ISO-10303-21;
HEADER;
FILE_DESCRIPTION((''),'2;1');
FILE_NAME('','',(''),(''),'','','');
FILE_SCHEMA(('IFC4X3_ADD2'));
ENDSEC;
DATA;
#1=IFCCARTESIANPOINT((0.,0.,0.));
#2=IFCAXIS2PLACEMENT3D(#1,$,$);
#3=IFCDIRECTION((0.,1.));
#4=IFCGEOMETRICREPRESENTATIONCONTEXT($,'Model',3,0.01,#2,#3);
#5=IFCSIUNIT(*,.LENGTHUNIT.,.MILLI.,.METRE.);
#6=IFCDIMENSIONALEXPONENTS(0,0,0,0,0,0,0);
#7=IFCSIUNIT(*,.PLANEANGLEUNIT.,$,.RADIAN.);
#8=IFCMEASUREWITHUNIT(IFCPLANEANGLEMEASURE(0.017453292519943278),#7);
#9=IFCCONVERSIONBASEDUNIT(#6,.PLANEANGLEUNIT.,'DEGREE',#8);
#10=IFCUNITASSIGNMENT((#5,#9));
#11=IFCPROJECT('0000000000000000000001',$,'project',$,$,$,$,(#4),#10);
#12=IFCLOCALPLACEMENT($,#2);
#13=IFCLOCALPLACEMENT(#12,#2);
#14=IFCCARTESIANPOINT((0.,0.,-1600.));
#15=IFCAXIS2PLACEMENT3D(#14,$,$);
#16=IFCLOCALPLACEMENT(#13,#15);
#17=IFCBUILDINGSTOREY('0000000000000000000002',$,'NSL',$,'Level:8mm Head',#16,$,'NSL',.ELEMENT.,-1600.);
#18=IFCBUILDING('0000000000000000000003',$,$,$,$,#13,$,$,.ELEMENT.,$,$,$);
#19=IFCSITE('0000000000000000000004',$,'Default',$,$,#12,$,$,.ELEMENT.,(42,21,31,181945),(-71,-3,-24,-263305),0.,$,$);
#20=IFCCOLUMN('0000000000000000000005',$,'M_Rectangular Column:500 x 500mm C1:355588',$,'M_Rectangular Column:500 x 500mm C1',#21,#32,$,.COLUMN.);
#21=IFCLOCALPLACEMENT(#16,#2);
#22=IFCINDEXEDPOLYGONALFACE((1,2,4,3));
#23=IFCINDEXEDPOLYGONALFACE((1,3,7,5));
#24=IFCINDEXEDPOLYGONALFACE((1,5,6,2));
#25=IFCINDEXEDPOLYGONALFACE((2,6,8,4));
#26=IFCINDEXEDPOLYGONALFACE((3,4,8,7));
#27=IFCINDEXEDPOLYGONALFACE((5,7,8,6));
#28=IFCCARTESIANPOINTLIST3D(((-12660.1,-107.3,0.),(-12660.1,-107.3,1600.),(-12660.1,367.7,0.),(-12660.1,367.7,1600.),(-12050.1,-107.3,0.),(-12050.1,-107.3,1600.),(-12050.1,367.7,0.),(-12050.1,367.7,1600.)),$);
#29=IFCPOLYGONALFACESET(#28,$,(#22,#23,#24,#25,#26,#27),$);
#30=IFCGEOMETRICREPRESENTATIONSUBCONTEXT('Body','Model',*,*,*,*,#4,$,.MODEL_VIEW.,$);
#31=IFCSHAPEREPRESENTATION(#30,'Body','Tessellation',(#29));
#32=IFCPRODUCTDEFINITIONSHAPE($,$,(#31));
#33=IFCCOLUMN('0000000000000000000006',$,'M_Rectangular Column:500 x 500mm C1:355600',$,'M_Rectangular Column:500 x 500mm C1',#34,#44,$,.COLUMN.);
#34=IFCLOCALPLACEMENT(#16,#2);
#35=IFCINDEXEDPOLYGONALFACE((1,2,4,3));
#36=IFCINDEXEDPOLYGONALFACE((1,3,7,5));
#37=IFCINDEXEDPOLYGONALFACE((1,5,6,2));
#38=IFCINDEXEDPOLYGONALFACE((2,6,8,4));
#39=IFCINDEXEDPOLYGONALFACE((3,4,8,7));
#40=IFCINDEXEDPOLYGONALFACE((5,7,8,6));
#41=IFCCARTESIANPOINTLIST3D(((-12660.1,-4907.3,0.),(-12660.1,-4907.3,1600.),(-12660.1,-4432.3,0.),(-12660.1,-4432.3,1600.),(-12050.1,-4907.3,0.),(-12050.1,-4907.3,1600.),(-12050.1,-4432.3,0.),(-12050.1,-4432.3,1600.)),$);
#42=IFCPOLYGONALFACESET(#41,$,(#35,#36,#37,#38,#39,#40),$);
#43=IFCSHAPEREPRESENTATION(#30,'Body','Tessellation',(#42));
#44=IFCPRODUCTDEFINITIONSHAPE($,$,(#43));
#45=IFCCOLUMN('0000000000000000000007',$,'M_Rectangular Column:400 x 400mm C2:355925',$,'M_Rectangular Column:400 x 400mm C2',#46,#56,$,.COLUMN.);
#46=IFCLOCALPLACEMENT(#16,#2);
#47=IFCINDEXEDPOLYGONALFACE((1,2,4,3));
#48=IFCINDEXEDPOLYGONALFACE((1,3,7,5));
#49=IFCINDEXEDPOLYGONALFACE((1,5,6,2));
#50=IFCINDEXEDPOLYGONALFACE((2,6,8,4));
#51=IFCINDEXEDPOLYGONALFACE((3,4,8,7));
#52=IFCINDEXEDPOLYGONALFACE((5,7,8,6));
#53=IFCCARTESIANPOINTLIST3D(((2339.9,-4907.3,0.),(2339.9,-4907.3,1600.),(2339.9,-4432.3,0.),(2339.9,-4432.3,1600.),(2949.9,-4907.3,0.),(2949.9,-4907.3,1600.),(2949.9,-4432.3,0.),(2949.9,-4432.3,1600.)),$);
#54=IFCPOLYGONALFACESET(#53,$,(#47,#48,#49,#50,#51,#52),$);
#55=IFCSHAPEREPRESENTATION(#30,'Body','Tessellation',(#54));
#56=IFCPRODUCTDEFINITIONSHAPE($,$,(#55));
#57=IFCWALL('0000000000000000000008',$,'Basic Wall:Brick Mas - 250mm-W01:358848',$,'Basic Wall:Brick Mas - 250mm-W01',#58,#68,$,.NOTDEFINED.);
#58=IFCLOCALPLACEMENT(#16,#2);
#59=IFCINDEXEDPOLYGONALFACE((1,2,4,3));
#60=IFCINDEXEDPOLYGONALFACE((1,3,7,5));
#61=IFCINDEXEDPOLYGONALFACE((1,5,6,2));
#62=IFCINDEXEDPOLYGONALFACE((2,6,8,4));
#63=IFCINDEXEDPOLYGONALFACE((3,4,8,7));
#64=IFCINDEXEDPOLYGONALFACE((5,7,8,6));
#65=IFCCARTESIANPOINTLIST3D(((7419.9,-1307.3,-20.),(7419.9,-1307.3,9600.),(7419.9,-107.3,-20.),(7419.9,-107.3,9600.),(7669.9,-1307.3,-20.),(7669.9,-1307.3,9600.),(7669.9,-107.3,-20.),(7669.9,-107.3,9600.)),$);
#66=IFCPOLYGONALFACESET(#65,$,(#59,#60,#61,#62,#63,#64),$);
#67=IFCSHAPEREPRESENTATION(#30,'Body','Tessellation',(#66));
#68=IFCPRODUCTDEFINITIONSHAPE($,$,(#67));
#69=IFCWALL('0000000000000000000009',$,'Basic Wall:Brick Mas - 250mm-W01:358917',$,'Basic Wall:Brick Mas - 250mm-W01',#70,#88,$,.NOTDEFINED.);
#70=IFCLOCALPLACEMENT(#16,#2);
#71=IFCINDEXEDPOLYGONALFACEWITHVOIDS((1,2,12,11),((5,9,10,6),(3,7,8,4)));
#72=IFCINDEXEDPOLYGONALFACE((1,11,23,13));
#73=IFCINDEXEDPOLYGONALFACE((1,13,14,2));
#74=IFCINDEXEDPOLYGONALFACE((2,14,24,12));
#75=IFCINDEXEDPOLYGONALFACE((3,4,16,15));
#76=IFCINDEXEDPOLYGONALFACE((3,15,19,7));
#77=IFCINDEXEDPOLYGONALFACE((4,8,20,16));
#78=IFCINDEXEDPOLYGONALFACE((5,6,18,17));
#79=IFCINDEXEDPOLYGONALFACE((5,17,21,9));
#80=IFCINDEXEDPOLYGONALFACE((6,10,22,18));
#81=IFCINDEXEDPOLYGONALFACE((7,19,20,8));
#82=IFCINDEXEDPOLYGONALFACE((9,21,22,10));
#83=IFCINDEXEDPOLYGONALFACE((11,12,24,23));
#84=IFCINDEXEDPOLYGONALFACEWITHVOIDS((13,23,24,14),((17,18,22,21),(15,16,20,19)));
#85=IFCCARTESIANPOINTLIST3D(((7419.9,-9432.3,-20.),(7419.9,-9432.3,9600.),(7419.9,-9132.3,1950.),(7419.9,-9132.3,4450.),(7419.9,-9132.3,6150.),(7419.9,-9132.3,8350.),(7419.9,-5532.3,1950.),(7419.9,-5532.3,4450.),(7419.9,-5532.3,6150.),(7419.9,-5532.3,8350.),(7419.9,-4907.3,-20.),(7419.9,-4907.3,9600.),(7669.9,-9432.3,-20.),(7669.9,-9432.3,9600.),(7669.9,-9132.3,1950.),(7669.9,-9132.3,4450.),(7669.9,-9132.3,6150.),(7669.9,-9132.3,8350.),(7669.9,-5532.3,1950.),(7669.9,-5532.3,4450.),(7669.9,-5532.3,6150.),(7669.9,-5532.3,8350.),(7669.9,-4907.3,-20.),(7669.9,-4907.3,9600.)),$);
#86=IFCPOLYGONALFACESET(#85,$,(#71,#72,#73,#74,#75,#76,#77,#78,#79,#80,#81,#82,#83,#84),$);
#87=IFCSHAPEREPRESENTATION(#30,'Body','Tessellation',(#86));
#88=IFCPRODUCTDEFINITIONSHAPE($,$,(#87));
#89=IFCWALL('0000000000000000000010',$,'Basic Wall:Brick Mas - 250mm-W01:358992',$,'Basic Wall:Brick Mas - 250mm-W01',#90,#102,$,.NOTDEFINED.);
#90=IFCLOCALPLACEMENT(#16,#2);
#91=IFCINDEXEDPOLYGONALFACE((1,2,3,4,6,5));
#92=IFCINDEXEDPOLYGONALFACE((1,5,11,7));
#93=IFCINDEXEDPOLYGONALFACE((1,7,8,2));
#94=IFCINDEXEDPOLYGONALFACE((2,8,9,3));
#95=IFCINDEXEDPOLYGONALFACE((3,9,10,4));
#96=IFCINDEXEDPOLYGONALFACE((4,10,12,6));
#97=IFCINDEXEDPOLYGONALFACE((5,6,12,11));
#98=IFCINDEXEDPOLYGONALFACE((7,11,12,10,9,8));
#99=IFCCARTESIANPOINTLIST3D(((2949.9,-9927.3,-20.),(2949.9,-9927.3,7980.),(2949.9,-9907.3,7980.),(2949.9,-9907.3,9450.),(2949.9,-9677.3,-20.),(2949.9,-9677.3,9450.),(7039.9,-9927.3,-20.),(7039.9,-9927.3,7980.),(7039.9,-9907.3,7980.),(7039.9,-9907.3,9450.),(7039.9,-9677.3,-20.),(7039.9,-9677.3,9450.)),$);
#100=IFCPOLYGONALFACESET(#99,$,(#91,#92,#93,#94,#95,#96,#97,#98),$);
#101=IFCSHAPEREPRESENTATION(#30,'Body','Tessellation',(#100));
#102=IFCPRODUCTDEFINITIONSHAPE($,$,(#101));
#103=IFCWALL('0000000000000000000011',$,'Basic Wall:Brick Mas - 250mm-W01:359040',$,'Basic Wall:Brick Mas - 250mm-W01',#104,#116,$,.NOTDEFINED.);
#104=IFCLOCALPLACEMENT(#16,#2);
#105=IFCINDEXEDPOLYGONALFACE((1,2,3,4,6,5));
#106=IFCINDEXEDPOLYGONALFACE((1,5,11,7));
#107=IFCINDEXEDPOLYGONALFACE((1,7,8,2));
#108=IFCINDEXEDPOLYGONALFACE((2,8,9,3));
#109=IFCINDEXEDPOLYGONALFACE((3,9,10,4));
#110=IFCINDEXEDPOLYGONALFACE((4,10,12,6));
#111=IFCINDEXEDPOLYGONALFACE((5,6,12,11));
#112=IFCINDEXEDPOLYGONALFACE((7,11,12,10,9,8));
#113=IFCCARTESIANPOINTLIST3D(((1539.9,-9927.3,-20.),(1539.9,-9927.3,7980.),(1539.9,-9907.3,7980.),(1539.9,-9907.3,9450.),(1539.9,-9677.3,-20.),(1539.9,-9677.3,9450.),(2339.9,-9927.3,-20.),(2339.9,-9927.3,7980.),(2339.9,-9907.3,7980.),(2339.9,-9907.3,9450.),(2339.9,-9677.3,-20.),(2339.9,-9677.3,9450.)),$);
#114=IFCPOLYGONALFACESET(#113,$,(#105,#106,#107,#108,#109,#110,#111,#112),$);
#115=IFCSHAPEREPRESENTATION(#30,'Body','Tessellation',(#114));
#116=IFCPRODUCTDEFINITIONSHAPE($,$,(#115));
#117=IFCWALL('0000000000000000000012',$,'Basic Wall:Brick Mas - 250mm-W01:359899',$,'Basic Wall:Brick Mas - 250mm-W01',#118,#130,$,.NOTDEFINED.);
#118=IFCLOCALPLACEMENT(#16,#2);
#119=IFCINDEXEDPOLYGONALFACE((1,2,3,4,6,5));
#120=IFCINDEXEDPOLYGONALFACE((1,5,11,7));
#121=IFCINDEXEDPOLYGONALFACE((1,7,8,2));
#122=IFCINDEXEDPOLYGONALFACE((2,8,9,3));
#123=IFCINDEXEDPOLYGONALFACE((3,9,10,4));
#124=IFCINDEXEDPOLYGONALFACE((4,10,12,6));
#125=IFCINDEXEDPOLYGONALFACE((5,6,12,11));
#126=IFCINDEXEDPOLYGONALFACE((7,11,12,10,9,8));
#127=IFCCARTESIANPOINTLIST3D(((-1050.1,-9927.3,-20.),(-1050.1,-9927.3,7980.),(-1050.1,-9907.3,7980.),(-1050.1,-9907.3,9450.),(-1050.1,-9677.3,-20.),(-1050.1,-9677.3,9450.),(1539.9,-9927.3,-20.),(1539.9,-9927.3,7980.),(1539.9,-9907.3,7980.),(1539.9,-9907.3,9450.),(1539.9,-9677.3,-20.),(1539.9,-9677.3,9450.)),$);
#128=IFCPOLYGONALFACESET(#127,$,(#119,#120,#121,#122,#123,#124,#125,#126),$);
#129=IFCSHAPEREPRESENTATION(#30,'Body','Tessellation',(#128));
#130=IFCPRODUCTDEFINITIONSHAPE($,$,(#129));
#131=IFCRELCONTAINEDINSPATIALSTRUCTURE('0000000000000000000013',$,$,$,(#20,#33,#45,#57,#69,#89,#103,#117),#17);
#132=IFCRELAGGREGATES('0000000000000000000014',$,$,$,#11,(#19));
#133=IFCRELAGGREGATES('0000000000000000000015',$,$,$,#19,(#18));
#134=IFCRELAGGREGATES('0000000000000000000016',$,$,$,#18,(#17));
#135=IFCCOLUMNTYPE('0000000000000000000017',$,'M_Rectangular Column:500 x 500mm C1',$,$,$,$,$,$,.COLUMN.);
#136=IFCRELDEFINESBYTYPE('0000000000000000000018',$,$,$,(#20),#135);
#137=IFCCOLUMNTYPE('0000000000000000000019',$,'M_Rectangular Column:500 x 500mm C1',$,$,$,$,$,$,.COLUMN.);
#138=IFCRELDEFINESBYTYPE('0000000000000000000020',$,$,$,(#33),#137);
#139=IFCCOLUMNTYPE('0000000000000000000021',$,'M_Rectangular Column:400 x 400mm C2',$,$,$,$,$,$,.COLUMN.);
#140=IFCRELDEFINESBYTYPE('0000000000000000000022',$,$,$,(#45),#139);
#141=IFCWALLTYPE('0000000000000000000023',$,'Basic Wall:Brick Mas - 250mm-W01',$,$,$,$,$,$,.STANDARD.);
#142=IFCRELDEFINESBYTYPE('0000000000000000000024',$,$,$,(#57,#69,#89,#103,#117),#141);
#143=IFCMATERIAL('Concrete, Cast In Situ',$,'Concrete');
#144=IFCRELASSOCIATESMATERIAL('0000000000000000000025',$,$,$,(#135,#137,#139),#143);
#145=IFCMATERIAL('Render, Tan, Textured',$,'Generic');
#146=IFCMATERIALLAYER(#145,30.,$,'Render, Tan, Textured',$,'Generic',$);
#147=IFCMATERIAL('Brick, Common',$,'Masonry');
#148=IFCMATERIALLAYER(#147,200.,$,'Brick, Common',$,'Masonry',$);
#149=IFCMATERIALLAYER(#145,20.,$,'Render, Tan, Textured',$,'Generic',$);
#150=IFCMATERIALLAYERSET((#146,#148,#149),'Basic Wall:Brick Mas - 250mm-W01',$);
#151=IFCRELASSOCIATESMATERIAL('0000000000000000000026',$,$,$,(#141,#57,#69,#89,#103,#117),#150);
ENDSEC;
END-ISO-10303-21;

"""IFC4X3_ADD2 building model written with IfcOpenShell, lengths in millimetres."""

from ifc_helpers import new_model, entity, si_unit, converted_unit, direction, frame, frame_2d, origin, origin_2d_with_axis, place, context, subcontext, project, spatial, polyline, rectangle, extrude, clip, bounded_halfspace, source, transform, mapped, material, layer, layer_set, material_profile, profile_set, type_object, type_shapes, element, save


model = new_model("IFC4X3_ADD2")

# Units and contexts
model_context = context("Model", 3, precision=0.01, world=origin(), true_north=direction((0.0, 1.0)))
body_context = subcontext(model_context, "Body", "Model", "MODEL_VIEW")
ifc_project = project(units=[si_unit("LENGTHUNIT", "METRE", prefix="MILLI"), converted_unit("PLANEANGLEUNIT", "DEGREE", entity("IfcPlaneAngleMeasure", 0.017453292519943278), si_unit("PLANEANGLEUNIT", "RADIAN"), dimensions=[0, 0, 0, 0, 0, 0, 0])], contexts=[model_context])

# Site, building, storey
site_placement = place(None, origin())
site = spatial("IfcSite", under=ifc_project, at=site_placement, Name="Default", CompositionType="ELEMENT", RefLatitude=(42, 21, 31, 181945), RefLongitude=(-71, -3, -24, -263305), RefElevation=0.0)
building_placement = place(site_placement, origin())
building = spatial("IfcBuilding", under=site, at=building_placement, CompositionType="ELEMENT")
storey_placement = place(building_placement, frame((0.0, 0.0, -1600.0)))
storey = spatial("IfcBuildingStorey", under=building, at=storey_placement, Name="NSL", ObjectType="Level:8mm Head", LongName="NSL", CompositionType="ELEMENT", Elevation=-1600.0)

# Columns
ifc_material_1 = material(Name="Concrete, Cast In Situ", Category="Concrete")
ifc_material_profile_1 = material_profile(ifc_material_1, rectangle(XDim=610.0, YDim=475.0, at=frame_2d((0.0, 0.0), x_axis=(1.0, 0.0))), Name="500 x 500mm C1")
ifc_profile_set_1 = profile_set([ifc_material_profile_1], Name="500 x 500mm C1")
column_type_1 = type_object("IfcColumnType", Name="M_Rectangular Column:500 x 500mm C1", PredefinedType="COLUMN", material=ifc_profile_set_1)
shared_shape_1 = source(origin(), body_context, "Body", "SweptSolid", [
    extrude(rectangle(XDim=610.0, YDim=475.0, at=origin_2d_with_axis()), frame((-12355.1, 130.2, -1600.0), z_axis=(0.0, 0.0, 1.0), x_axis=(-1.0, 0.0, 0.0)), (0.0, 0.0, 1.0), 1600.0),
])
type_shapes(column_type_1, [shared_shape_1])
column_1_placement = place(storey_placement, frame((0.0, 0.0, 1600.0)))
element("IfcColumn", 1, at=column_1_placement, inside=storey, type_object=column_type_1, Name="M_Rectangular Column:500 x 500mm C1:355588", ObjectType="M_Rectangular Column:500 x 500mm C1", PredefinedType="COLUMN", context=body_context, shape_type="MappedRepresentation", body=[
    mapped(shared_shape_1, transform((0.0, 0.0, 0.0), scale=1.0)),
])
column_type_2 = type_object("IfcColumnType", Name="M_Rectangular Column:500 x 500mm C1", PredefinedType="COLUMN", material=ifc_profile_set_1)
shared_shape_2 = source(origin(), body_context, "Body", "SweptSolid", [
    extrude(rectangle(XDim=610.0, YDim=475.0, at=frame_2d((0.0, 0.0), x_axis=(1.0, 0.0))), frame((-12355.1, -4669.8, -1600.0), z_axis=(0.0, 0.0, 1.0), x_axis=(-1.0, 0.0, 0.0)), (0.0, 0.0, 1.0), 1600.0),
])
type_shapes(column_type_2, [shared_shape_2])
column_2_placement = place(storey_placement, frame((0.0, 0.0, 1600.0)))
element("IfcColumn", 2, at=column_2_placement, inside=storey, type_object=column_type_2, Name="M_Rectangular Column:500 x 500mm C1:355600", ObjectType="M_Rectangular Column:500 x 500mm C1", PredefinedType="COLUMN", context=body_context, shape_type="MappedRepresentation", body=[
    mapped(shared_shape_2, transform((0.0, 0.0, 0.0), scale=1.0)),
])
ifc_material_profile_2 = material_profile(ifc_material_1, rectangle(XDim=610.0, YDim=475.0, at=origin_2d_with_axis()), Name="400 x 400mm C2")
ifc_profile_set_2 = profile_set([ifc_material_profile_2], Name="400 x 400mm C2")
column_type_3 = type_object("IfcColumnType", Name="M_Rectangular Column:400 x 400mm C2", PredefinedType="COLUMN", material=ifc_profile_set_2)
shared_shape_3 = source(origin(), body_context, "Body", "SweptSolid", [
    extrude(rectangle(XDim=610.0, YDim=475.0, at=origin_2d_with_axis()), frame((0.0, 0.0, -1600.0), z_axis=(0.0, 0.0, 1.0), x_axis=(-1.0, 0.0, 0.0)), (0.0, 0.0, 1.0), 1600.0),
])
type_shapes(column_type_3, [shared_shape_3])
column_3_placement = place(storey_placement, frame((2644.9, -4669.8, 1600.0)))
element("IfcColumn", 3, at=column_3_placement, inside=storey, type_object=column_type_3, Name="M_Rectangular Column:400 x 400mm C2:355925", ObjectType="M_Rectangular Column:400 x 400mm C2", PredefinedType="COLUMN", context=body_context, shape_type="MappedRepresentation", body=[
    mapped(shared_shape_3, transform((0.0, 0.0, 0.0), scale=1.0)),
])

# Wall
ifc_material_2 = material(Name="Render, Tan, Textured", Category="Generic")
ifc_layer_1 = layer(ifc_material_2, 30.0, Name="Render, Tan, Textured", Category="Generic")
ifc_material_3 = material(Name="Brick, Common", Category="Masonry")
ifc_layer_2 = layer(ifc_material_3, 200.0, Name="Brick, Common", Category="Masonry")
ifc_layer_3 = layer(ifc_material_2, 20.0, Name="Render, Tan, Textured", Category="Generic")
ifc_layer_set = layer_set([ifc_layer_1, ifc_layer_2, ifc_layer_3], Name="Basic Wall:Brick Mas - 250mm-W01")
wall_type = type_object("IfcWallType", Name="Basic Wall:Brick Mas - 250mm-W01", PredefinedType="STANDARD", material=ifc_layer_set)
wall_1_placement = place(storey_placement, frame((7544.9, -107.3, -20.0), z_axis=(0.0, 0.0, 1.0), x_axis=(0.0, -1.0, 0.0)))
element("IfcWall", 4, at=wall_1_placement, inside=storey, type_object=wall_type, material=ifc_layer_set, Name="Basic Wall:Brick Mas - 250mm-W01:358848", ObjectType="Basic Wall:Brick Mas - 250mm-W01", PredefinedType="NOTDEFINED", context=body_context, shape_type="SweptSolid", body=[
    extrude(rectangle(XDim=1200.0, YDim=250.0, at=frame_2d((600.0, 0.0), x_axis=(-1.0, 0.0))), origin(), (0.0, 0.0, 1.0), 9620.0),
])

# Wall, openings
wall_2_placement = place(storey_placement, frame((7544.9, -4907.3, -20.0), z_axis=(0.0, 0.0, 1.0), x_axis=(0.0, -1.0, 0.0)))
wall_2 = element("IfcWall", 5, at=wall_2_placement, inside=storey, type_object=wall_type, material=ifc_layer_set, Name="Basic Wall:Brick Mas - 250mm-W01:358917", ObjectType="Basic Wall:Brick Mas - 250mm-W01", PredefinedType="NOTDEFINED", context=body_context, shape_type="SweptSolid", body=[
    extrude(rectangle(XDim=4525.0, YDim=250.0, at=frame_2d((2262.5, 0.0), x_axis=(-1.0, 0.0))), origin(), (0.0, 0.0, 1.0), 9620.0),
])
opening_1_placement = place(wall_2_placement, origin())
element("IfcOpeningElement", 6, at=opening_1_placement, cuts=wall_2, PredefinedType="OPENING", context=body_context, shape_type="SweptSolid", body=[
    extrude(rectangle(XDim=2500.0, YDim=3600.0, at=frame_2d((0.0, 0.0), x_axis=(0.0, 1.0))), frame((2425.0, 125.0, 3220.0), z_axis=(0.0, -1.0, 0.0), x_axis=(-1.0, 0.0, 0.0)), (0.0, 0.0, 1.0), 250.0),
])
opening_2_placement = place(wall_2_placement, origin())
element("IfcOpeningElement", 7, at=opening_2_placement, cuts=wall_2, PredefinedType="OPENING", context=body_context, shape_type="SweptSolid", body=[
    extrude(rectangle(XDim=2200.0, YDim=3600.0, at=frame_2d((0.0, 0.0), x_axis=(0.0, 1.0))), frame((2425.0, 125.0, 7270.0), z_axis=(0.0, -1.0, 0.0), x_axis=(-1.0, 0.0, 0.0)), (0.0, 0.0, 1.0), 250.0),
])

# Walls
wall_3_placement = place(storey_placement, frame((7039.9, -9802.3, -20.0), z_axis=(0.0, 0.0, 1.0), x_axis=(-1.0, 0.0, 0.0)))
element("IfcWall", 8, at=wall_3_placement, inside=storey, type_object=wall_type, material=ifc_layer_set, Name="Basic Wall:Brick Mas - 250mm-W01:358992", ObjectType="Basic Wall:Brick Mas - 250mm-W01", PredefinedType="NOTDEFINED", context=body_context, shape_type="Clipping", body=[
    clip(clip(extrude(rectangle(XDim=4090.0, YDim=250.0, at=frame_2d((2045.0, 0.0), x_axis=(-1.0, 0.0))), origin(), (0.0, 0.0, 1.0), 9470.0), bounded_halfspace(frame((0.0, -125.0, 9470.0), z_axis=(0.0, 0.0, -1.0), x_axis=(0.0, 1.0, 0.0)), True, frame((0.0, -125.0, 9470.0)), polyline([(0.0, 0.0), (4090.0, 0.0), (4090.0, 230.0), (0.0, 230.0), (0.0, 0.0)]))), bounded_halfspace(frame((4090.0, 105.0, 8000.0), z_axis=(0.0, 0.0, 1.0), x_axis=(0.0, 1.0, 0.0)), False, frame((4090.0, 105.0, 8000.0)), polyline([(0.0, 0.0), (0.0, 20.0), (-4090.0, 20.0), (-4090.0, 0.0), (0.0, 0.0)]))),
])
wall_4_placement = place(storey_placement, frame((2339.9, -9802.3, -20.0), z_axis=(0.0, 0.0, 1.0), x_axis=(-1.0, 0.0, 0.0)))
element("IfcWall", 9, at=wall_4_placement, inside=storey, type_object=wall_type, material=ifc_layer_set, Name="Basic Wall:Brick Mas - 250mm-W01:359040", ObjectType="Basic Wall:Brick Mas - 250mm-W01", PredefinedType="NOTDEFINED", context=body_context, shape_type="Clipping", body=[
    clip(clip(extrude(rectangle(XDim=800.0, YDim=250.0, at=frame_2d((400.0, 0.0), x_axis=(-1.0, 0.0))), origin(), (0.0, 0.0, 1.0), 9470.0), bounded_halfspace(frame((0.0, -125.0, 9470.0), z_axis=(0.0, 0.0, -1.0), x_axis=(0.0, 1.0, 0.0)), True, frame((0.0, -125.0, 9470.0)), polyline([(0.0, 0.0), (800.0, 0.0), (800.0, 230.0), (0.0, 230.0), (0.0, 0.0)]))), bounded_halfspace(frame((800.0, 105.0, 8000.0), z_axis=(0.0, 0.0, 1.0), x_axis=(0.0, 1.0, 0.0)), False, frame((800.0, 105.0, 8000.0)), polyline([(0.0, 0.0), (0.0, 20.0), (-800.0, 20.0), (-800.0, 0.0), (0.0, 0.0)]))),
])
wall_5_placement = place(storey_placement, frame((1539.9, -9802.3, -20.0), z_axis=(0.0, 0.0, 1.0), x_axis=(-1.0, 0.0, 0.0)))
element("IfcWall", 10, at=wall_5_placement, inside=storey, type_object=wall_type, material=ifc_layer_set, Name="Basic Wall:Brick Mas - 250mm-W01:359899", ObjectType="Basic Wall:Brick Mas - 250mm-W01", PredefinedType="NOTDEFINED", context=body_context, shape_type="Clipping", body=[
    clip(clip(extrude(rectangle(XDim=2590.0, YDim=250.0, at=frame_2d((1295.0, 0.0), x_axis=(-1.0, 0.0))), origin(), (0.0, 0.0, 1.0), 9470.0), bounded_halfspace(frame((0.0, -125.0, 9470.0), z_axis=(0.0, 0.0, -1.0), x_axis=(0.0, 1.0, 0.0)), True, frame((0.0, -125.0, 9470.0)), polyline([(0.0, 0.0), (2590.0, 0.0), (2590.0, 230.0), (0.0, 230.0), (0.0, 0.0)]))), bounded_halfspace(frame((2590.0, 105.0, 8000.0), z_axis=(0.0, 0.0, 1.0), x_axis=(0.0, 1.0, 0.0)), False, frame((2590.0, 105.0, 8000.0)), polyline([(0.0, 0.0), (0.0, 20.0), (-2590.0, 20.0), (-2590.0, 0.0), (0.0, 0.0)]))),
])

save(model, "model.ifc")
